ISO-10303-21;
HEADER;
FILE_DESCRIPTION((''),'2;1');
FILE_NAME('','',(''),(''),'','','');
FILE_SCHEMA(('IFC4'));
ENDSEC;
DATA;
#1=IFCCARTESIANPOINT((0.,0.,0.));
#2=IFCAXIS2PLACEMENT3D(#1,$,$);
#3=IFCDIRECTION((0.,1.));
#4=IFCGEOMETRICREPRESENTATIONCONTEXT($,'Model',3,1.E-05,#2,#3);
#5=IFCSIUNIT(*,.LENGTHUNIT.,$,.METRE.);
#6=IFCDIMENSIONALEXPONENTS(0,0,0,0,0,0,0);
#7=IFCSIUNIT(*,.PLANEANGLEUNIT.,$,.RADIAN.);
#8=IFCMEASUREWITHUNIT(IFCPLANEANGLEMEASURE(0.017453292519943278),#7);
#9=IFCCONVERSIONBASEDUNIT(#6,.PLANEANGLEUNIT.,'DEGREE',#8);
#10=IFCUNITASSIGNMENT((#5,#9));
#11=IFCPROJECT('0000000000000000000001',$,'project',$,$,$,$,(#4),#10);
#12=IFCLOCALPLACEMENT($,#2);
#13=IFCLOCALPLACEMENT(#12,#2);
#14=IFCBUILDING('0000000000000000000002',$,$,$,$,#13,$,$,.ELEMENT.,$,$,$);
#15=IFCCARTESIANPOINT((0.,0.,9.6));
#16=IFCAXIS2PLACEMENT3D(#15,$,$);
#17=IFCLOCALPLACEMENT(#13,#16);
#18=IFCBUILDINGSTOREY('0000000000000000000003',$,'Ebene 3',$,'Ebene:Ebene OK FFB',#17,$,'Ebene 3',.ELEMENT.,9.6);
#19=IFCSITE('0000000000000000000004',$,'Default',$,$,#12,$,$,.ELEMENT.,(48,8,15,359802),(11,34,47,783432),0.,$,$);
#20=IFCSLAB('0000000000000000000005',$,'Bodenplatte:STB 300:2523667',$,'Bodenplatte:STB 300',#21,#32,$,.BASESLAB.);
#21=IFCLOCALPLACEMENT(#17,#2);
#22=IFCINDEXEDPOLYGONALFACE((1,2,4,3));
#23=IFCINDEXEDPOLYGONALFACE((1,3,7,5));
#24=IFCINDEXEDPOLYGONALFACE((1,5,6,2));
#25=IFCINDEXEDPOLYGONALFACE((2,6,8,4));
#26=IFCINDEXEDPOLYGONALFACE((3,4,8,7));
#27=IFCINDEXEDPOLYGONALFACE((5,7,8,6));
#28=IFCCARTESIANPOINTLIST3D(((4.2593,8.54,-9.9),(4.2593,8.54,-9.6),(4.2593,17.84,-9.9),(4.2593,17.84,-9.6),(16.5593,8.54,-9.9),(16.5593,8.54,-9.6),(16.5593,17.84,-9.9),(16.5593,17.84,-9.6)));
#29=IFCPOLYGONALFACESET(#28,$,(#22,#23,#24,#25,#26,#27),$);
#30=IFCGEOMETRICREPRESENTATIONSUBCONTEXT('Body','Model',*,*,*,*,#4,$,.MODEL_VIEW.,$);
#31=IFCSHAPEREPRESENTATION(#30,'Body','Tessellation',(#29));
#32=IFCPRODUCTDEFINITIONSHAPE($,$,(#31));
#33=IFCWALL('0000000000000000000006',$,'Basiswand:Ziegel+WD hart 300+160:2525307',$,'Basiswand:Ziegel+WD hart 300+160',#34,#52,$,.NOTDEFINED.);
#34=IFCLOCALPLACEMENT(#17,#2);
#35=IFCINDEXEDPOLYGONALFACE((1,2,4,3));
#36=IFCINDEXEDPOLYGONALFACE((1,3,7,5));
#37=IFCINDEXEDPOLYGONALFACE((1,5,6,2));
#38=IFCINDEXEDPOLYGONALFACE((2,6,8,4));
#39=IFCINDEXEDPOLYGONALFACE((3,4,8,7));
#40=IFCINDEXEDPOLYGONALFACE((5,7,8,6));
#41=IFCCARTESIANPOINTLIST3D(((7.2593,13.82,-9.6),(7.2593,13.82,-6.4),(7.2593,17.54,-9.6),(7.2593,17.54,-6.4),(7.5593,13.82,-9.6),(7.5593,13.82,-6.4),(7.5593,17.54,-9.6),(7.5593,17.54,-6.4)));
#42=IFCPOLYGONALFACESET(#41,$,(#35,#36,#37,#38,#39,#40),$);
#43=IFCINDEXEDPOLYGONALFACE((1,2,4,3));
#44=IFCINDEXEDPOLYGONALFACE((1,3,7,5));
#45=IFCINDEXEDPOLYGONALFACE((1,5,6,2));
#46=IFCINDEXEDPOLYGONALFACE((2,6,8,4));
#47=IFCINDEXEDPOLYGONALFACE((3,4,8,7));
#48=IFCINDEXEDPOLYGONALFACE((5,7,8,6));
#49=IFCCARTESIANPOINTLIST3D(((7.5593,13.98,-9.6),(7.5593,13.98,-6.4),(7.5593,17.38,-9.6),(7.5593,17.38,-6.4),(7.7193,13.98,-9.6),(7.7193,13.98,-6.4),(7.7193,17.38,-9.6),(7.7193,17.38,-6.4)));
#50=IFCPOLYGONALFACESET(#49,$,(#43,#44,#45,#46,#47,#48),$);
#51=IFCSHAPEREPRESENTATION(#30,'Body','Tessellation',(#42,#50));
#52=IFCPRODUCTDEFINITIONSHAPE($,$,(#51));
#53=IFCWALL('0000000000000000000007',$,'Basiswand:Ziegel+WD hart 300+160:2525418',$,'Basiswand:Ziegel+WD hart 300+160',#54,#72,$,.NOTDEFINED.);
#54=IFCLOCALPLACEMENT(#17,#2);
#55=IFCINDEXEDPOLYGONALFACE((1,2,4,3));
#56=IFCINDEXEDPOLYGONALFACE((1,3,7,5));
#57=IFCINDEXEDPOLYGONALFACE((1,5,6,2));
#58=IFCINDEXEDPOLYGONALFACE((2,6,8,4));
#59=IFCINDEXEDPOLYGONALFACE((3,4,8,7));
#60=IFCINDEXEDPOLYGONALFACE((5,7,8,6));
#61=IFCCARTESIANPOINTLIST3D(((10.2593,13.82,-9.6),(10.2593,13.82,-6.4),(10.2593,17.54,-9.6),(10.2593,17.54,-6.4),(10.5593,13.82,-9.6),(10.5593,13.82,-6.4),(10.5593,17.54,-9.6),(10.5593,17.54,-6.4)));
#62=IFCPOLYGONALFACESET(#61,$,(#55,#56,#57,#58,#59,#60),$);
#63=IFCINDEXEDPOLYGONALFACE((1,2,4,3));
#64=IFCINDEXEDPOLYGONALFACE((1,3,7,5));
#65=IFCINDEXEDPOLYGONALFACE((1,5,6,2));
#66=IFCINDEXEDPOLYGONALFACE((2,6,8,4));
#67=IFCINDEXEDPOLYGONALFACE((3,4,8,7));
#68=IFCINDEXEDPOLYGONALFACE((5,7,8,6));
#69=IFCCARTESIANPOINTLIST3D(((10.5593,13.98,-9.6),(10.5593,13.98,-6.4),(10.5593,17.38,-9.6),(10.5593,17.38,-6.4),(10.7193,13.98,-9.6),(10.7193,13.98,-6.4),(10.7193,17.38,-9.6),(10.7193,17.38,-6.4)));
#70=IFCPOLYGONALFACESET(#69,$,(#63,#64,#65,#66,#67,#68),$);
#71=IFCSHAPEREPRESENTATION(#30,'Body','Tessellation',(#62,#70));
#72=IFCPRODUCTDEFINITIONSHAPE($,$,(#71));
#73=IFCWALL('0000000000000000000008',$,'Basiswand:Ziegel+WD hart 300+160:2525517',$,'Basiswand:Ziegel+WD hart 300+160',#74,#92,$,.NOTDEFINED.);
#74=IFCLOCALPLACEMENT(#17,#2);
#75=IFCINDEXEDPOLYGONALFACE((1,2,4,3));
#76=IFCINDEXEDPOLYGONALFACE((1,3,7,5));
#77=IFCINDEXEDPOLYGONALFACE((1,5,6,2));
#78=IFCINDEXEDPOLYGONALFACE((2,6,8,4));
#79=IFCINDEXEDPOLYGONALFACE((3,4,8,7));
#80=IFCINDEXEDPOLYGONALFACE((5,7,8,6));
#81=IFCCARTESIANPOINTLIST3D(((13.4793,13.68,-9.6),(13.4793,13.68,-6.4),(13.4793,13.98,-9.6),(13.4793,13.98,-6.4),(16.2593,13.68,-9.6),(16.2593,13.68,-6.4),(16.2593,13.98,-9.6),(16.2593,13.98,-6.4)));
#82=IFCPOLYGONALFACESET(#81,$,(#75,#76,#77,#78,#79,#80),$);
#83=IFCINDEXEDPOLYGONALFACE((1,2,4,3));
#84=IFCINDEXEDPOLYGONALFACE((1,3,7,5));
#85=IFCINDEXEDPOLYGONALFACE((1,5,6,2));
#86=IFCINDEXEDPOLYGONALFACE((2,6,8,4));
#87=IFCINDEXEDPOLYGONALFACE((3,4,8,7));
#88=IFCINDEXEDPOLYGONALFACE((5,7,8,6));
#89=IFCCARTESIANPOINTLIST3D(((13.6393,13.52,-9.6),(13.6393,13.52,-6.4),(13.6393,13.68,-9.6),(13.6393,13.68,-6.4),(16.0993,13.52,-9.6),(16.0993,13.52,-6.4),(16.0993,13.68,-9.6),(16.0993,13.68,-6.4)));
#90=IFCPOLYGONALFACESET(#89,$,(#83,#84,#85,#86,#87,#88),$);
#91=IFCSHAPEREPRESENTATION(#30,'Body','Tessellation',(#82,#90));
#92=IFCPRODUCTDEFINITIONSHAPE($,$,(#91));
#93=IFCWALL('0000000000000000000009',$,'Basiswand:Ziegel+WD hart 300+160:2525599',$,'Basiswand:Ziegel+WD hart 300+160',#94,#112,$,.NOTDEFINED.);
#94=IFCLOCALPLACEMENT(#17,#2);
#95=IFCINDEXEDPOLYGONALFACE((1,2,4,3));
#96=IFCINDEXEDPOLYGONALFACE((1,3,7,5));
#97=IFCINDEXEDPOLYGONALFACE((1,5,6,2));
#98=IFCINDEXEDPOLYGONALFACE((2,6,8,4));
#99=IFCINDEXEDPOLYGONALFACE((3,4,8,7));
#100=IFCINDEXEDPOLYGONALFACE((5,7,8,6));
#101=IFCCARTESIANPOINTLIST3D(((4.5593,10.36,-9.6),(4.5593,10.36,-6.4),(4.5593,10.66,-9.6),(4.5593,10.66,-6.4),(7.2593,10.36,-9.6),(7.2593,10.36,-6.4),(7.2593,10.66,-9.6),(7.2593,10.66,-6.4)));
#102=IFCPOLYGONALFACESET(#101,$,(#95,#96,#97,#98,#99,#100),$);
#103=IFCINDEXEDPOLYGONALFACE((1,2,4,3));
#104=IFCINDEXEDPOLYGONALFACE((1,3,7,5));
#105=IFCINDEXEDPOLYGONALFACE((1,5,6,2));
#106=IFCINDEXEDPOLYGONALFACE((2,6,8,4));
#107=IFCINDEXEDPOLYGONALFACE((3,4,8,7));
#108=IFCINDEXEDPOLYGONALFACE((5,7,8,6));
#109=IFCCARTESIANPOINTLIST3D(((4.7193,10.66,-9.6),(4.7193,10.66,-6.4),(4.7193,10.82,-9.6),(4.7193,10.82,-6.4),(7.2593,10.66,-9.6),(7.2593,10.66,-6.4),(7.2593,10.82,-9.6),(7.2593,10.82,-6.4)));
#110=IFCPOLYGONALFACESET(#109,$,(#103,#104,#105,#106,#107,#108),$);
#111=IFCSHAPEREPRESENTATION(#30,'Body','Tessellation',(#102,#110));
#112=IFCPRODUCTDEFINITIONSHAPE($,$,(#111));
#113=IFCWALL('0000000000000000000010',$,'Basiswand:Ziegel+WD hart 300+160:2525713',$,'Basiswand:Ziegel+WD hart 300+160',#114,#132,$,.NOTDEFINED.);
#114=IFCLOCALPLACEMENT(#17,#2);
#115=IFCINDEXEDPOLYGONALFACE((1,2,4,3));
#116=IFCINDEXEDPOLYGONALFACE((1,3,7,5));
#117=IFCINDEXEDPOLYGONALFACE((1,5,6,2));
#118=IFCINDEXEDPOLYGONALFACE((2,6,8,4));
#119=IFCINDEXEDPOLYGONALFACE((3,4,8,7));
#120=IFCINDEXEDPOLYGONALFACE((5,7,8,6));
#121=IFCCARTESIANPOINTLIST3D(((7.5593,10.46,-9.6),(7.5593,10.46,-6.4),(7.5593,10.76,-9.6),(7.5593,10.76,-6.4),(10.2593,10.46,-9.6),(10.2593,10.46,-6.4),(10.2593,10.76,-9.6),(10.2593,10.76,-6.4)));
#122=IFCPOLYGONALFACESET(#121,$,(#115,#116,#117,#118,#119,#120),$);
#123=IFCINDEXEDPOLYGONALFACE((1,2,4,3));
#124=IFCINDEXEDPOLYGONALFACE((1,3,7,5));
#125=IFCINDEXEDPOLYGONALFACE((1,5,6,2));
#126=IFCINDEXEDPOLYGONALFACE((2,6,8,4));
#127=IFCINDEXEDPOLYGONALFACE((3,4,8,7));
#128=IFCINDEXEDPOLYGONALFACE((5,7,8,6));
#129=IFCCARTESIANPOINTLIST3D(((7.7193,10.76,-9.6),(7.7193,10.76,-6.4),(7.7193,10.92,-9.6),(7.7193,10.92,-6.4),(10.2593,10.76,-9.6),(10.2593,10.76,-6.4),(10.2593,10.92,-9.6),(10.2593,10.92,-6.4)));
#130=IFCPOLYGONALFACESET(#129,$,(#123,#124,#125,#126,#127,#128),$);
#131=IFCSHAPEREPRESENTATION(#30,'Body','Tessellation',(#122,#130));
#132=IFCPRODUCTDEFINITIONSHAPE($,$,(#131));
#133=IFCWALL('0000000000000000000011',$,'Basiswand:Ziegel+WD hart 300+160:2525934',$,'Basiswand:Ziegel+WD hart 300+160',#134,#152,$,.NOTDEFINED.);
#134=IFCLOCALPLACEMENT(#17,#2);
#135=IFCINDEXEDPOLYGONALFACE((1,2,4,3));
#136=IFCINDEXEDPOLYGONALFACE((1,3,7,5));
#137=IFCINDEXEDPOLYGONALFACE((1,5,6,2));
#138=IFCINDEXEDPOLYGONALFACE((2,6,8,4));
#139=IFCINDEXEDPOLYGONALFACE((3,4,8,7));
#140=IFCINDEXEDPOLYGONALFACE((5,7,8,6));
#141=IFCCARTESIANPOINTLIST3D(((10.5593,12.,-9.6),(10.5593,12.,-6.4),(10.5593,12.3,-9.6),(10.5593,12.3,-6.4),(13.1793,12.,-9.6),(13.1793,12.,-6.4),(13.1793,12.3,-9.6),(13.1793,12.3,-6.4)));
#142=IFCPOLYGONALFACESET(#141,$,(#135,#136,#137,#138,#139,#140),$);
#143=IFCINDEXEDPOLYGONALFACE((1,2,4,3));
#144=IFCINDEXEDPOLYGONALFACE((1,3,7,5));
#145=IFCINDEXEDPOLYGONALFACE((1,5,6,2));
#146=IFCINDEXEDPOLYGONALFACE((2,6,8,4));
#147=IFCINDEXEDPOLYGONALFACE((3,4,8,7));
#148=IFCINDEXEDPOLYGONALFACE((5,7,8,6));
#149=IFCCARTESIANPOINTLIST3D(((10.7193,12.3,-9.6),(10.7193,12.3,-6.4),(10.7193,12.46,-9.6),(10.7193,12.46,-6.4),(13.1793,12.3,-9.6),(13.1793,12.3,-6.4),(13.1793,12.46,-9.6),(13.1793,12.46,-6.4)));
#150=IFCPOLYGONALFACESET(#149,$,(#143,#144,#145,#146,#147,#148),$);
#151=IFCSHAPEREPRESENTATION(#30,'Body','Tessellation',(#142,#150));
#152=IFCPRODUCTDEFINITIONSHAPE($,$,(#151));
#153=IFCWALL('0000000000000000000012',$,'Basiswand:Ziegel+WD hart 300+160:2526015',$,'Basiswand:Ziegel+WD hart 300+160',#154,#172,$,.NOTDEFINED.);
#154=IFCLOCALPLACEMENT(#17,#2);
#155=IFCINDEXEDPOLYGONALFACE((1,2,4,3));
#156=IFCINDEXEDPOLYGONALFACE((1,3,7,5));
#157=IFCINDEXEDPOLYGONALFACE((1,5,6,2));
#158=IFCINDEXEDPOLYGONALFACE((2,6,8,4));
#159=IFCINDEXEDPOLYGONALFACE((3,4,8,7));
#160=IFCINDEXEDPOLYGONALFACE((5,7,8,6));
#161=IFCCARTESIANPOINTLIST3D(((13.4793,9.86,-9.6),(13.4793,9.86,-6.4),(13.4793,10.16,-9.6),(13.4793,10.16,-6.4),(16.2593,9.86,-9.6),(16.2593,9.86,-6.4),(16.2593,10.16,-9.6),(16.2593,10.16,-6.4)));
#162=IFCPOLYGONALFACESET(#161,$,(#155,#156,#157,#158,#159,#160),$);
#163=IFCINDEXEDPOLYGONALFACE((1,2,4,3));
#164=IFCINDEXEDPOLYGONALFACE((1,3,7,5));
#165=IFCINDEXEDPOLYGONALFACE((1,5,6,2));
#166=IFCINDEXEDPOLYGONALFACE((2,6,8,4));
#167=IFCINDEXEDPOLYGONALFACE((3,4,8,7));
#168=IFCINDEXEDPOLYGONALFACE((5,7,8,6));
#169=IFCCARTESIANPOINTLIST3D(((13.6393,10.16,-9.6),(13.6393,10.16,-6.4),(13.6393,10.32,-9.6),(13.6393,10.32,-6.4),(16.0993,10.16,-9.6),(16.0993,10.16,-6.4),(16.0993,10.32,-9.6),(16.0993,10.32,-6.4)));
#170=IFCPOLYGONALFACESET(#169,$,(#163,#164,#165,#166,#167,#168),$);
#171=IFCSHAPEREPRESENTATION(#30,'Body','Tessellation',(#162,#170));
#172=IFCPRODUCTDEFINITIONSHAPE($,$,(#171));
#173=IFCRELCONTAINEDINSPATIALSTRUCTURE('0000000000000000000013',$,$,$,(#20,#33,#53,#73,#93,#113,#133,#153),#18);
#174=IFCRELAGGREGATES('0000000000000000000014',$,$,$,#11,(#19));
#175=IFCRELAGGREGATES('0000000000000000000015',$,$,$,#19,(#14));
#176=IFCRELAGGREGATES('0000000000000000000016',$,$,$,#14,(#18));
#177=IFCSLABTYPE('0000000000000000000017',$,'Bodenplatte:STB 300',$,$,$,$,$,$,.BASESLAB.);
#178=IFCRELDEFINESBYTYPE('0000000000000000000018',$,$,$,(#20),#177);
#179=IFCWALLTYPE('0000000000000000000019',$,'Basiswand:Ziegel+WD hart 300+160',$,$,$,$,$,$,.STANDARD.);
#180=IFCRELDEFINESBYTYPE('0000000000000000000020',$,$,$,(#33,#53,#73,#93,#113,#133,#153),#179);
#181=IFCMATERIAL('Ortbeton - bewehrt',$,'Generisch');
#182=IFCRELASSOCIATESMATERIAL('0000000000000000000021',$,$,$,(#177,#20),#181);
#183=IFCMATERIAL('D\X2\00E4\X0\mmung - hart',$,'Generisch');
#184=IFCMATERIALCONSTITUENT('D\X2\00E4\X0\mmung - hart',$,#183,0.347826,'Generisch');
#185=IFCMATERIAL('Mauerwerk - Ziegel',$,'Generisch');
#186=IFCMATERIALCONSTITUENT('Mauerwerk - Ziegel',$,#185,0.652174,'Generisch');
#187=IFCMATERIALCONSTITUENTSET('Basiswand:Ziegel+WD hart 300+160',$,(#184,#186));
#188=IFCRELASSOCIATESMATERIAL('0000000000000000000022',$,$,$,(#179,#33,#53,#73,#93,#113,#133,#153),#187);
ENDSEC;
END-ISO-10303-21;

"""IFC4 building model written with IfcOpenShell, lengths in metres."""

from ifc_helpers import new_model, entity, si_unit, converted_unit, direction, frame, origin, place, context, subcontext, project, spatial, indexed_curve, outline, extrude, material, constituent, constituent_set, type_object, element, save


model = new_model("IFC4")

# Units and contexts
model_context = context("Model", 3, precision=1e-05, world=origin(), true_north=direction((0.0, 1.0)))
body_context = subcontext(model_context, "Body", "Model", "MODEL_VIEW")
ifc_project = project(units=[si_unit("LENGTHUNIT", "METRE"), converted_unit("PLANEANGLEUNIT", "DEGREE", entity("IfcPlaneAngleMeasure", 0.017453292519943278), si_unit("PLANEANGLEUNIT", "RADIAN"), dimensions=[0, 0, 0, 0, 0, 0, 0])], contexts=[model_context])

# Site, building, storey
site_placement = place(None, origin())
site = spatial("IfcSite", under=ifc_project, at=site_placement, Name="Default", CompositionType="ELEMENT", RefLatitude=(48, 8, 15, 359802), RefLongitude=(11, 34, 47, 783432), RefElevation=0.0)
building_placement = place(site_placement, origin())
building = spatial("IfcBuilding", under=site, at=building_placement, CompositionType="ELEMENT")
storey_placement = place(building_placement, frame((0.0, 0.0, 9.6)))
storey = spatial("IfcBuildingStorey", under=building, at=storey_placement, Name="Ebene 3", ObjectType="Ebene:Ebene OK FFB", LongName="Ebene 3", CompositionType="ELEMENT", Elevation=9.6)

# Slab
ifc_material_1 = material(Name="Ortbeton - bewehrt", Category="Generisch")
slab_type = type_object("IfcSlabType", Name="Bodenplatte:STB 300", PredefinedType="BASESLAB", material=ifc_material_1)
slab_placement = place(storey_placement, origin())
element("IfcSlab", 1, at=slab_placement, inside=storey, type_object=slab_type, material=ifc_material_1, Name="Bodenplatte:STB 300:2523667", ObjectType="Bodenplatte:STB 300", PredefinedType="BASESLAB", context=body_context, shape_type="SweptSolid", body=[
    extrude(outline(indexed_curve([(-4.65, -6.15), (4.65, -6.15), (4.65, 6.15), (-4.65, 6.15), (-4.65, -6.15)], self_intersect=False)), frame((10.4093, 13.19, -9.6), z_axis=(0.0, 0.0, -1.0), x_axis=(0.0, 1.0, 0.0)), (0.0, 0.0, 1.0), 0.3),
])

# Walls
ifc_material_2 = material(Name="Dämmung - hart", Category="Generisch")
ifc_constituent_1 = constituent(ifc_material_2, Name="Dämmung - hart", Category="Generisch", fraction=0.347826)
ifc_material_3 = material(Name="Mauerwerk - Ziegel", Category="Generisch")
ifc_constituent_2 = constituent(ifc_material_3, Name="Mauerwerk - Ziegel", Category="Generisch", fraction=0.652174)
ifc_constituent_set = constituent_set(constituents=[ifc_constituent_1, ifc_constituent_2], Name="Basiswand:Ziegel+WD hart 300+160")
wall_type = type_object("IfcWallType", Name="Basiswand:Ziegel+WD hart 300+160", PredefinedType="STANDARD", material=ifc_constituent_set)
wall_1_placement = place(storey_placement, frame((7.4893, 17.38, -9.6), z_axis=(0.0, 0.0, 1.0), x_axis=(0.0, -1.0, 0.0)))
element("IfcWall", 2, at=wall_1_placement, inside=storey, type_object=wall_type, material=ifc_constituent_set, Name="Basiswand:Ziegel+WD hart 300+160:2525307", ObjectType="Basiswand:Ziegel+WD hart 300+160", PredefinedType="NOTDEFINED", context=body_context, shape_type="SweptSolid", body=[
    extrude(outline(indexed_curve([(-0.15, -1.86), (0.15, -1.86), (0.15, 1.86), (-0.15, 1.86), (-0.15, -1.86)], self_intersect=False)), frame((1.7, -0.08, 0.0), z_axis=(0.0, 0.0, 1.0), x_axis=(0.0, 1.0, 0.0)), (0.0, 0.0, 1.0), 3.2),
    extrude(outline(indexed_curve([(-0.08, -1.7), (0.08, -1.7), (0.08, 1.7), (-0.08, 1.7), (-0.08, -1.7)], self_intersect=False)), frame((1.7, 0.15, 0.0), z_axis=(0.0, 0.0, 1.0), x_axis=(0.0, -1.0, 0.0)), (0.0, 0.0, 1.0), 3.2),
])
wall_2_placement = place(storey_placement, frame((10.4893, 17.38, -9.6), z_axis=(0.0, 0.0, 1.0), x_axis=(0.0, -1.0, 0.0)))
element("IfcWall", 3, at=wall_2_placement, inside=storey, type_object=wall_type, material=ifc_constituent_set, Name="Basiswand:Ziegel+WD hart 300+160:2525418", ObjectType="Basiswand:Ziegel+WD hart 300+160", PredefinedType="NOTDEFINED", context=body_context, shape_type="SweptSolid", body=[
    extrude(outline(indexed_curve([(-0.15, -1.86), (0.15, -1.86), (0.15, 1.86), (-0.15, 1.86), (-0.15, -1.86)], self_intersect=False)), frame((1.7, -0.08, 0.0), z_axis=(0.0, 0.0, 1.0), x_axis=(0.0, 1.0, 0.0)), (0.0, 0.0, 1.0), 3.2),
    extrude(outline(indexed_curve([(-0.08, -1.7), (0.08, -1.7), (0.08, 1.7), (-0.08, 1.7), (-0.08, -1.7)], self_intersect=False)), frame((1.7, 0.15, 0.0), z_axis=(0.0, 0.0, 1.0), x_axis=(0.0, -1.0, 0.0)), (0.0, 0.0, 1.0), 3.2),
])
wall_3_placement = place(storey_placement, frame((13.6393, 13.75, -9.6)))
element("IfcWall", 4, at=wall_3_placement, inside=storey, type_object=wall_type, material=ifc_constituent_set, Name="Basiswand:Ziegel+WD hart 300+160:2525517", ObjectType="Basiswand:Ziegel+WD hart 300+160", PredefinedType="NOTDEFINED", context=body_context, shape_type="SweptSolid", body=[
    extrude(outline(indexed_curve([(-0.15, -1.39), (0.15, -1.39), (0.15, 1.39), (-0.15, 1.39), (-0.15, -1.39)], self_intersect=False)), frame((1.23, 0.08, 0.0), z_axis=(0.0, 0.0, 1.0), x_axis=(0.0, -1.0, 0.0)), (0.0, 0.0, 1.0), 3.2),
    extrude(outline(indexed_curve([(-0.08, -1.23), (0.08, -1.23), (0.08, 1.23), (-0.08, 1.23), (-0.08, -1.23)], self_intersect=False)), frame((1.23, -0.15, 0.0), z_axis=(0.0, 0.0, 1.0), x_axis=(0.0, 1.0, 0.0)), (0.0, 0.0, 1.0), 3.2),
])
wall_4_placement = place(storey_placement, frame((4.7193, 10.59, -9.6)))
element("IfcWall", 5, at=wall_4_placement, inside=storey, type_object=wall_type, material=ifc_constituent_set, Name="Basiswand:Ziegel+WD hart 300+160:2525599", ObjectType="Basiswand:Ziegel+WD hart 300+160", PredefinedType="NOTDEFINED", context=body_context, shape_type="SweptSolid", body=[
    extrude(outline(indexed_curve([(-0.15, -1.35), (0.15, -1.35), (0.15, 1.35), (-0.15, 1.35), (-0.15, -1.35)], self_intersect=False)), frame((1.19, -0.08, 0.0), z_axis=(0.0, 0.0, 1.0), x_axis=(0.0, 1.0, 0.0)), (0.0, 0.0, 1.0), 3.2),
    extrude(outline(indexed_curve([(-0.08, -1.27), (0.08, -1.27), (0.08, 1.27), (-0.08, 1.27), (-0.08, -1.27)], self_intersect=False)), frame((1.27, 0.15, 0.0), z_axis=(0.0, 0.0, 1.0), x_axis=(0.0, -1.0, 0.0)), (0.0, 0.0, 1.0), 3.2),
])
wall_5_placement = place(storey_placement, frame((7.7193, 10.69, -9.6)))
element("IfcWall", 6, at=wall_5_placement, inside=storey, type_object=wall_type, material=ifc_constituent_set, Name="Basiswand:Ziegel+WD hart 300+160:2525713", ObjectType="Basiswand:Ziegel+WD hart 300+160", PredefinedType="NOTDEFINED", context=body_context, shape_type="SweptSolid", body=[
    extrude(outline(indexed_curve([(-0.15, -1.35), (0.15, -1.35), (0.15, 1.35), (-0.15, 1.35), (-0.15, -1.35)], self_intersect=False)), frame((1.19, -0.08, 0.0), z_axis=(0.0, 0.0, 1.0), x_axis=(0.0, 1.0, 0.0)), (0.0, 0.0, 1.0), 3.2),
    extrude(outline(indexed_curve([(-0.08, -1.27), (0.08, -1.27), (0.08, 1.27), (-0.08, 1.27), (-0.08, -1.27)], self_intersect=False)), frame((1.27, 0.15, 0.0), z_axis=(0.0, 0.0, 1.0), x_axis=(0.0, -1.0, 0.0)), (0.0, 0.0, 1.0), 3.2),
])
wall_6_placement = place(storey_placement, frame((10.7193, 12.23, -9.6)))
element("IfcWall", 7, at=wall_6_placement, inside=storey, type_object=wall_type, material=ifc_constituent_set, Name="Basiswand:Ziegel+WD hart 300+160:2525934", ObjectType="Basiswand:Ziegel+WD hart 300+160", PredefinedType="NOTDEFINED", context=body_context, shape_type="SweptSolid", body=[
    extrude(outline(indexed_curve([(-0.15, -1.31), (0.15, -1.31), (0.15, 1.31), (-0.15, 1.31), (-0.15, -1.31)], self_intersect=False)), frame((1.15, -0.08, 0.0), z_axis=(0.0, 0.0, 1.0), x_axis=(0.0, 1.0, 0.0)), (0.0, 0.0, 1.0), 3.2),
    extrude(outline(indexed_curve([(-0.08, -1.23), (0.08, -1.23), (0.08, 1.23), (-0.08, 1.23), (-0.08, -1.23)], self_intersect=False)), frame((1.23, 0.15, 0.0), z_axis=(0.0, 0.0, 1.0), x_axis=(0.0, -1.0, 0.0)), (0.0, 0.0, 1.0), 3.2),
])
wall_7_placement = place(storey_placement, frame((13.6393, 10.09, -9.6)))
element("IfcWall", 8, at=wall_7_placement, inside=storey, type_object=wall_type, material=ifc_constituent_set, Name="Basiswand:Ziegel+WD hart 300+160:2526015", ObjectType="Basiswand:Ziegel+WD hart 300+160", PredefinedType="NOTDEFINED", context=body_context, shape_type="SweptSolid", body=[
    extrude(outline(indexed_curve([(-0.15, -1.39), (0.15, -1.39), (0.15, 1.39), (-0.15, 1.39), (-0.15, -1.39)], self_intersect=False)), frame((1.23, -0.08, 0.0), z_axis=(0.0, 0.0, 1.0), x_axis=(0.0, 1.0, 0.0)), (0.0, 0.0, 1.0), 3.2),
    extrude(outline(indexed_curve([(-0.08, -1.23), (0.08, -1.23), (0.08, 1.23), (-0.08, 1.23), (-0.08, -1.23)], self_intersect=False)), frame((1.23, 0.15, 0.0), z_axis=(0.0, 0.0, 1.0), x_axis=(0.0, -1.0, 0.0)), (0.0, 0.0, 1.0), 3.2),
])

save(model, "model.ifc")
